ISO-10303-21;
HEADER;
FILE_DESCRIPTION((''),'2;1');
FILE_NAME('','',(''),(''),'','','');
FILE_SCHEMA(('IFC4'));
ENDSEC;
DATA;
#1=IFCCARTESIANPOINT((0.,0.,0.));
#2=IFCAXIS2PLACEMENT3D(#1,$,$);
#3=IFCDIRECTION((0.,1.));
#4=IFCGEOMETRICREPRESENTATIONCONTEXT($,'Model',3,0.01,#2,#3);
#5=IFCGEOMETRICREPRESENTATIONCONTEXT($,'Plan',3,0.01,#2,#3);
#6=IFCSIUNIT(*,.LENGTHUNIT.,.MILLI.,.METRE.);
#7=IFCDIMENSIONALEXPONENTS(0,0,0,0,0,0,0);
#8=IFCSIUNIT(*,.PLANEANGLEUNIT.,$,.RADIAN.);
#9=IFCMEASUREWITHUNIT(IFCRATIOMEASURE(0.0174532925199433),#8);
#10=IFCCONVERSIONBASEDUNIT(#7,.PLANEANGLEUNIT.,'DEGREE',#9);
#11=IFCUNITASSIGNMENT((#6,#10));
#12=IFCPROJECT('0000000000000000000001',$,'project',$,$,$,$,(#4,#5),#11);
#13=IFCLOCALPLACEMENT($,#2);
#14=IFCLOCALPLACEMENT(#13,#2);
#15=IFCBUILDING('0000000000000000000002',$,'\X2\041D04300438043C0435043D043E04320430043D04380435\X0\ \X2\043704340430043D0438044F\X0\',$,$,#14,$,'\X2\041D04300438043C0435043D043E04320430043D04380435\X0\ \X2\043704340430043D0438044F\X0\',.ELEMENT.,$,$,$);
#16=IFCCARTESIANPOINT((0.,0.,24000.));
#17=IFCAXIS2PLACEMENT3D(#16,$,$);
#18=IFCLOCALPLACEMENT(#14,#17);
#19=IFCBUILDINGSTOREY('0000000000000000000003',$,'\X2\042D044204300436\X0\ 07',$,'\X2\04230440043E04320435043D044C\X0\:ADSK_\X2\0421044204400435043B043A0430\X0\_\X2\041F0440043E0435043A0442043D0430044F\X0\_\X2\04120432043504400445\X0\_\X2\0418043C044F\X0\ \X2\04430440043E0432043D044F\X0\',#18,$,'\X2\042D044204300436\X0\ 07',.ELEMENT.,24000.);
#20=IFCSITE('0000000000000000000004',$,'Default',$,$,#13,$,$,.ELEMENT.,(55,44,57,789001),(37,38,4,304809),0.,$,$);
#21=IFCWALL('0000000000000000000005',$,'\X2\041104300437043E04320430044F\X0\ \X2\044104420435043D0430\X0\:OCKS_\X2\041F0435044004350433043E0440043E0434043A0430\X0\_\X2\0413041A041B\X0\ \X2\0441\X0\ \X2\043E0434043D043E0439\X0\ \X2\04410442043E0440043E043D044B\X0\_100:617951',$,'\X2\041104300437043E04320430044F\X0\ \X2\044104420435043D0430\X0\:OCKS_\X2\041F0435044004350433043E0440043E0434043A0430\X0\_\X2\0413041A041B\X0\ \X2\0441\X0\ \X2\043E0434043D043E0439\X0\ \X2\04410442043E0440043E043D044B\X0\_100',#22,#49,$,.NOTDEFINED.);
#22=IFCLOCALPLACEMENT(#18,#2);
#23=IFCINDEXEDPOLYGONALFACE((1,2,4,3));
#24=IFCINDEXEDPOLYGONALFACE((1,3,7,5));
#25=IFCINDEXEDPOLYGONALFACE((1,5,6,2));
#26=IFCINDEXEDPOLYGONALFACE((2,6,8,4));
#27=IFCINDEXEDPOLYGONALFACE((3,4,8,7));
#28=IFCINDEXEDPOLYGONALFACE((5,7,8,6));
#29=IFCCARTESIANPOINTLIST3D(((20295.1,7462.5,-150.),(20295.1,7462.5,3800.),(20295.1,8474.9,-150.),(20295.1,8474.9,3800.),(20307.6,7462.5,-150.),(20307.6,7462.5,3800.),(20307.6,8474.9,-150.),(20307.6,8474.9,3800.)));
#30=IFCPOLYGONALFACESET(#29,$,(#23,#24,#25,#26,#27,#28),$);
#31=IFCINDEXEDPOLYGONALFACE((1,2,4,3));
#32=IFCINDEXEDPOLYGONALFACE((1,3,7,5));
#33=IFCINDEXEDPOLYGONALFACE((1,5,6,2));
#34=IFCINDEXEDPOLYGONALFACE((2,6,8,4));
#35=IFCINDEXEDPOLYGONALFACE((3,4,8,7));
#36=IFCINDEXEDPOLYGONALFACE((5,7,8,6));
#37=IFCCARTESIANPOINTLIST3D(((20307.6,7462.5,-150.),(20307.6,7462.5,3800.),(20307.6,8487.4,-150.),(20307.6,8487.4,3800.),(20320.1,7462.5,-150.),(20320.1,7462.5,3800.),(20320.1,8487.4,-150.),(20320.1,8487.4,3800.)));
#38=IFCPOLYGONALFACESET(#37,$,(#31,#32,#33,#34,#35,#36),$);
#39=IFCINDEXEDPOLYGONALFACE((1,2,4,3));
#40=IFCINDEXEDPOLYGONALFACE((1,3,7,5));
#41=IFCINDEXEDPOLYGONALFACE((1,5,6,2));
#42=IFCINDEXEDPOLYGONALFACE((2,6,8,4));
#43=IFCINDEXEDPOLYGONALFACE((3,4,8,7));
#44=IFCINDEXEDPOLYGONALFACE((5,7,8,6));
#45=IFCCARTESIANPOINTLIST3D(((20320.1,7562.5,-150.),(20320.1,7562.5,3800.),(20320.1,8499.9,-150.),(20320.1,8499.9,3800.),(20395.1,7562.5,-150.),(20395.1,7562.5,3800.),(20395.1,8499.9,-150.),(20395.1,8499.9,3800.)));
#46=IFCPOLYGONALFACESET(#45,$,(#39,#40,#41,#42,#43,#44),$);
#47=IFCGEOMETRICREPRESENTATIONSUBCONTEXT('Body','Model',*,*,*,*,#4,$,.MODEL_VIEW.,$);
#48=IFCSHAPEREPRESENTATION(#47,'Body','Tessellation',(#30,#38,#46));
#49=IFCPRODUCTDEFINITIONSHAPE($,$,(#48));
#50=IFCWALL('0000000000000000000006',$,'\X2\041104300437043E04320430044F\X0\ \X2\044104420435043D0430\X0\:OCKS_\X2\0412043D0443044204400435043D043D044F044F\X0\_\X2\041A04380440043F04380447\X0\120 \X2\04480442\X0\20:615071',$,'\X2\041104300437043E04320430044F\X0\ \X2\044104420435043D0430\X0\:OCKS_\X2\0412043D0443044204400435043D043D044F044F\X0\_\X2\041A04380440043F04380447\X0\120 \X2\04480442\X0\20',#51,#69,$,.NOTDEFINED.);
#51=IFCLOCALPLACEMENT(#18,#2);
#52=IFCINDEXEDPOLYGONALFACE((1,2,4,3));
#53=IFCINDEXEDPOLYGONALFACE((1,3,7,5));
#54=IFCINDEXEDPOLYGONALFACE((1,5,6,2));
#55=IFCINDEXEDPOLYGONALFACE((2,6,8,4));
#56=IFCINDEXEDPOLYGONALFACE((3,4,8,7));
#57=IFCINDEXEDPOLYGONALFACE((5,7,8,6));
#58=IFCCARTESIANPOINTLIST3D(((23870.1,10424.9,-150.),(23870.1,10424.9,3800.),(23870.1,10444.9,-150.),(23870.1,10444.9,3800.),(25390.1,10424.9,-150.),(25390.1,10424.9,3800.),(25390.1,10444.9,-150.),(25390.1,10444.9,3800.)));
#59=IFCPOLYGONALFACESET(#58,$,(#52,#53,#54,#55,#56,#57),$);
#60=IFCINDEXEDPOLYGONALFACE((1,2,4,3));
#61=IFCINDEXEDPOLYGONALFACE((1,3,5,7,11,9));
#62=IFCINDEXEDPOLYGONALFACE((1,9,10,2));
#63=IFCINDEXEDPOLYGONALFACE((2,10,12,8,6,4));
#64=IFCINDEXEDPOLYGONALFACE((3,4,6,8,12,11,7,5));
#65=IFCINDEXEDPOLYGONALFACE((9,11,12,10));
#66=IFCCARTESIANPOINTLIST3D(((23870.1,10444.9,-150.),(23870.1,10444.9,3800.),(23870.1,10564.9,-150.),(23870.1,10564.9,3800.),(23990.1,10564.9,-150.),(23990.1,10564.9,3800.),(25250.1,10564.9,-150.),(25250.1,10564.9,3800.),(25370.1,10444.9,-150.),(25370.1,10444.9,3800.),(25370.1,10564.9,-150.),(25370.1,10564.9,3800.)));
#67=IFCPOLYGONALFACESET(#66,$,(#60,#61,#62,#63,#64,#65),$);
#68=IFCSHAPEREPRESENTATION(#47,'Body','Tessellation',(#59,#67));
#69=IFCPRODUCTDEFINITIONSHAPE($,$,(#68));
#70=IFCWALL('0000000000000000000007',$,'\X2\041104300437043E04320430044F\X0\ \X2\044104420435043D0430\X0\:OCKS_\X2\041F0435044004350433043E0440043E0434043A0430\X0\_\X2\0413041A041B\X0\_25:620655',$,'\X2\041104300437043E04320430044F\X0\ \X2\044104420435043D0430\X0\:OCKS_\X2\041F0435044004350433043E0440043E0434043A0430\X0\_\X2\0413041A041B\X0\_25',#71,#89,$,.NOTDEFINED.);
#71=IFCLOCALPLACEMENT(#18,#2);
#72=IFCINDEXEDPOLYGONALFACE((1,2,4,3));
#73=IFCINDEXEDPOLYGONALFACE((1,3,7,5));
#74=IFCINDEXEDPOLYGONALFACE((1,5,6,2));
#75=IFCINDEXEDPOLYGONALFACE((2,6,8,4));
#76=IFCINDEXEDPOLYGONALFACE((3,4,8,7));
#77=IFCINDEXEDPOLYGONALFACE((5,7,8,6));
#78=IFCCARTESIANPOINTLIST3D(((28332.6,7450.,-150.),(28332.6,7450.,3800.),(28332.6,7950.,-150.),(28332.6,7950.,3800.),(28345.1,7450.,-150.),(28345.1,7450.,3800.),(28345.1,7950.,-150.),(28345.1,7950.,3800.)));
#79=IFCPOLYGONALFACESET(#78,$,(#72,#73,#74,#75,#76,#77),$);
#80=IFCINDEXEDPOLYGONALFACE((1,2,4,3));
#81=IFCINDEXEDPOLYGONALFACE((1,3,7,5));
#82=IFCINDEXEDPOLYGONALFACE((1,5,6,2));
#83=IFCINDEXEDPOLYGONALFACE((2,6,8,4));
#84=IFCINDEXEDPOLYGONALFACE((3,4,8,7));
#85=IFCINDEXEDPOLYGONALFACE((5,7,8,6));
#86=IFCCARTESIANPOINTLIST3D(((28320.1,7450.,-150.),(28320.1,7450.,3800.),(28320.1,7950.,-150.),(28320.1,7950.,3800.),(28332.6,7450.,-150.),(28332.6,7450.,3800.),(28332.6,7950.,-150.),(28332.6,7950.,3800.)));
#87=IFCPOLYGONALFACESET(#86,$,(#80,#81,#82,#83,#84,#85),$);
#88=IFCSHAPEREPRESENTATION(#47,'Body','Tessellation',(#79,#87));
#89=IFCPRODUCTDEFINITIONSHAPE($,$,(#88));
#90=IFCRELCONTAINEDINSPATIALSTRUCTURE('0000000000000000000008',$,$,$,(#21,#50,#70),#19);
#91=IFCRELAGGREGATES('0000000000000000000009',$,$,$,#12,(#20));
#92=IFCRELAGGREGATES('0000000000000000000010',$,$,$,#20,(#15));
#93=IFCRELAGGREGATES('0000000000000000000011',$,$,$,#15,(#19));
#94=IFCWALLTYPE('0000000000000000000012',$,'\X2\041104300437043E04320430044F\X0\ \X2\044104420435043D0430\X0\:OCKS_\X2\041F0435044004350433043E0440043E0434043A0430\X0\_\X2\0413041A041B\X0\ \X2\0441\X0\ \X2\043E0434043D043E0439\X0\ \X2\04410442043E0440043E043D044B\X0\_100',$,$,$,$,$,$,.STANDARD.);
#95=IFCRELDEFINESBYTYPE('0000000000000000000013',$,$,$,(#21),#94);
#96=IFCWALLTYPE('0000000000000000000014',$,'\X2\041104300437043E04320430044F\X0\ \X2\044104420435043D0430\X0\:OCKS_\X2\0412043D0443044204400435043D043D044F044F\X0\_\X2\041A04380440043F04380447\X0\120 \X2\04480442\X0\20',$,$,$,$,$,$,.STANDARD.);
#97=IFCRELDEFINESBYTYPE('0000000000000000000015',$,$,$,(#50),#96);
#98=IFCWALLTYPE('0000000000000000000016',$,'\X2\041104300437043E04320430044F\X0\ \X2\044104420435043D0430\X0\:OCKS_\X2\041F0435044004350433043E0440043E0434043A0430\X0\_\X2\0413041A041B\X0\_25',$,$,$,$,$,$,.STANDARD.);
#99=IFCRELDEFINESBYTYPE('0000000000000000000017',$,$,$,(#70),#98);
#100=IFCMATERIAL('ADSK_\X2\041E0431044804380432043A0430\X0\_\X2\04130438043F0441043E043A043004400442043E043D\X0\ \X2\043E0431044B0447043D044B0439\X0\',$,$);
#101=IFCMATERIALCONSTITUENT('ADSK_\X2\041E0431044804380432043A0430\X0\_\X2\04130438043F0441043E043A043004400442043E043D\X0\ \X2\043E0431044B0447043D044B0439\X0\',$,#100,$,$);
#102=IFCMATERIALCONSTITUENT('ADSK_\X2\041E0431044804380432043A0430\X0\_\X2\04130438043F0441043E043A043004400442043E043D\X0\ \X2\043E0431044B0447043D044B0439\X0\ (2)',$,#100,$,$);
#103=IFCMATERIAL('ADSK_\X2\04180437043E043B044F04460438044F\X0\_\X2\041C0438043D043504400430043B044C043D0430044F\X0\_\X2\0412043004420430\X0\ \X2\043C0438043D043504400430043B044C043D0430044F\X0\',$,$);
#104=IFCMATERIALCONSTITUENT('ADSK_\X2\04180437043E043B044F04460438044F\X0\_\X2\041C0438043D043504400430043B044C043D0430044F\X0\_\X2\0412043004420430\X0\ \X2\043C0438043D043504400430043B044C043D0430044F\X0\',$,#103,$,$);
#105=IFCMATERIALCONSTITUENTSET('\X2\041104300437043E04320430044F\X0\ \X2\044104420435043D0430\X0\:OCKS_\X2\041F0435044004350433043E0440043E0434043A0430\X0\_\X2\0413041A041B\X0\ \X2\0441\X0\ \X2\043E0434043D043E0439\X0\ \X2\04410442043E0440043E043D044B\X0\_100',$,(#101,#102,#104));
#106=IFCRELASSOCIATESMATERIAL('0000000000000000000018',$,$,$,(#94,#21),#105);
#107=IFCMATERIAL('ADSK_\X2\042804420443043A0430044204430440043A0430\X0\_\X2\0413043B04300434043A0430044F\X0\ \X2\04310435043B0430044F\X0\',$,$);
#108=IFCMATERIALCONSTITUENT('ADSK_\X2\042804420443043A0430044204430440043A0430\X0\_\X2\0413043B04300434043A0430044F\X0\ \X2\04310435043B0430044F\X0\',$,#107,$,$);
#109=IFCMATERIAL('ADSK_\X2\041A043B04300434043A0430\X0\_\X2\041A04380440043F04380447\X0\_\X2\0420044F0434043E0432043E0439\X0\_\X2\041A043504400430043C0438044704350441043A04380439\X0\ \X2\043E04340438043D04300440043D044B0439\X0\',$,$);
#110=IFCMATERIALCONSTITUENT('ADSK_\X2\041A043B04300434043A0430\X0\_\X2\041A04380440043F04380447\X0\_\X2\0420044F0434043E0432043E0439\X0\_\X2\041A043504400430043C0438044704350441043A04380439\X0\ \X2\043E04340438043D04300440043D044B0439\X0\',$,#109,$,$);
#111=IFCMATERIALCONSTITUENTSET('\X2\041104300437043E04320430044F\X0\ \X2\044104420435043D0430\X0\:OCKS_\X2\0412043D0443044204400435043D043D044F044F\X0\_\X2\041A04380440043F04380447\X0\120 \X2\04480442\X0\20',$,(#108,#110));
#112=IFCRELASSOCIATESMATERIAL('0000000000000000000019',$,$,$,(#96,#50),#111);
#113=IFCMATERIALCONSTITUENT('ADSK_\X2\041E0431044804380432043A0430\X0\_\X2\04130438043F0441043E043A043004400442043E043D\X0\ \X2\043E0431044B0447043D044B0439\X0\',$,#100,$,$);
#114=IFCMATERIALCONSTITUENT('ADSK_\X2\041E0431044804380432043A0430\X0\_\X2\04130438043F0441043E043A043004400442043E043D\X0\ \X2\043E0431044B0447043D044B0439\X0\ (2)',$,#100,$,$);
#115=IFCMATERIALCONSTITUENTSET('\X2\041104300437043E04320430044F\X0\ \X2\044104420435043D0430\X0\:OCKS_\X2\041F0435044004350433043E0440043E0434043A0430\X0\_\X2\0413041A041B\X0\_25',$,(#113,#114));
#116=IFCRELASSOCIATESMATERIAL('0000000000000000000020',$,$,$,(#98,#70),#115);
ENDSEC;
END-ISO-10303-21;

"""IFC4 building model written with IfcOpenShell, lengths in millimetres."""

from ifc_helpers import new_model, entity, si_unit, converted_unit, direction, frame, origin, place, context, subcontext, project, spatial, indexed_curve, outline, extrude, material, constituent, constituent_set, type_object, element, save


model = new_model("IFC4")

# Units and contexts
model_context = context("Model", 3, precision=0.01, world=origin(), true_north=direction((0.0, 1.0)))
plan_context = context("Plan", 3, precision=0.01, world=origin(), true_north=direction((0.0, 1.0)))
body_context = subcontext(model_context, "Body", "Model", "MODEL_VIEW")
ifc_project = project(units=[si_unit("LENGTHUNIT", "METRE", prefix="MILLI"), converted_unit("PLANEANGLEUNIT", "DEGREE", entity("IfcRatioMeasure", 0.0174532925199433), si_unit("PLANEANGLEUNIT", "RADIAN"), dimensions=[0, 0, 0, 0, 0, 0, 0])], contexts=[model_context, plan_context])

# Site, building, storey
site_placement = place(None, frame((0.0, 0.0, 0.0)))
site = spatial("IfcSite", under=ifc_project, at=site_placement, Name="Default", CompositionType="ELEMENT", RefLatitude=(55, 44, 57, 789001), RefLongitude=(37, 38, 4, 304809), RefElevation=0.0)
building_placement = place(site_placement, origin())
building = spatial("IfcBuilding", under=site, at=building_placement, Name="Наименование здания", LongName="Наименование здания", CompositionType="ELEMENT")
storey_placement = place(building_placement, frame((0.0, 0.0, 24000.0)))
storey = spatial("IfcBuildingStorey", under=building, at=storey_placement, Name="Этаж 07", ObjectType="Уровень:ADSK_Стрелка_Проектная_Вверх_Имя уровня", LongName="Этаж 07", CompositionType="ELEMENT", Elevation=24000.0)

# Shared definitions
ifc_material_1 = material(Name="ADSK_Обшивка_Гипсокартон обычный")
ifc_material_2 = material(Name="ADSK_Изоляция_Минеральная_Вата минеральная")

# Walls
ifc_constituent_1 = constituent(ifc_material_1, Name="ADSK_Обшивка_Гипсокартон обычный")
ifc_constituent_2 = constituent(ifc_material_1, Name="ADSK_Обшивка_Гипсокартон обычный (2)")
ifc_constituent_3 = constituent(ifc_material_2, Name="ADSK_Изоляция_Минеральная_Вата минеральная")
ifc_constituent_set_1 = constituent_set(constituents=[ifc_constituent_1, ifc_constituent_2, ifc_constituent_3], Name="Базовая стена:OCKS_Перегородка_ГКЛ с одной стороны_100")
wall_type_1 = type_object("IfcWallType", Name="Базовая стена:OCKS_Перегородка_ГКЛ с одной стороны_100", PredefinedType="STANDARD", material=ifc_constituent_set_1)
wall_1_placement = place(storey_placement, frame((20345.1, 7562.5, -150.0), z_axis=(0.0, 0.0, 1.0), x_axis=(0.0, 1.0, 0.0)))
element("IfcWall", 1, at=wall_1_placement, inside=storey, type_object=wall_type_1, material=ifc_constituent_set_1, Name="Базовая стена:OCKS_Перегородка_ГКЛ с одной стороны_100:617951", ObjectType="Базовая стена:OCKS_Перегородка_ГКЛ с одной стороны_100", PredefinedType="NOTDEFINED", context=body_context, shape_type="SweptSolid", body=[
    extrude(outline(indexed_curve([(-6.3, -506.2), (6.2, -506.2), (6.2, 506.2), (-6.3, 506.2), (-6.3, -506.2)], self_intersect=False)), frame((406.2, 43.7, 0.0), z_axis=(0.0, 0.0, 1.0), x_axis=(0.0, -1.0, 0.0)), (0.0, 0.0, 1.0), 3950.0),
    extrude(outline(indexed_curve([(-512.5, -6.3), (512.5, -6.3), (512.5, 6.2), (-512.5, 6.2), (-512.5, -6.3)], self_intersect=False)), frame((412.5, 31.3, 0.0)), (0.0, 0.0, 1.0), 3950.0),
    extrude(outline(indexed_curve([(-37.5, -468.7), (37.5, -468.7), (37.5, 468.7), (-37.5, 468.7), (-37.5, -468.7)], self_intersect=False)), frame((468.7, -12.5, 0.0), z_axis=(0.0, 0.0, 1.0), x_axis=(0.0, 1.0, 0.0)), (0.0, 0.0, 1.0), 3950.0),
])
ifc_material_3 = material(Name="ADSK_Штукатурка_Гладкая белая")
ifc_constituent_4 = constituent(ifc_material_3, Name="ADSK_Штукатурка_Гладкая белая")
ifc_material_4 = material(Name="ADSK_Кладка_Кирпич_Рядовой_Керамический одинарный")
ifc_constituent_5 = constituent(ifc_material_4, Name="ADSK_Кладка_Кирпич_Рядовой_Керамический одинарный")
ifc_constituent_set_2 = constituent_set(constituents=[ifc_constituent_4, ifc_constituent_5], Name="Базовая стена:OCKS_Внутренняя_Кирпич120 шт20")
wall_type_2 = type_object("IfcWallType", Name="Базовая стена:OCKS_Внутренняя_Кирпич120 шт20", PredefinedType="STANDARD", material=ifc_constituent_set_2)
wall_2_placement = place(storey_placement, frame((23870.1, 10494.9, -150.0)))
element("IfcWall", 2, at=wall_2_placement, inside=storey, type_object=wall_type_2, material=ifc_constituent_set_2, Name="Базовая стена:OCKS_Внутренняя_Кирпич120 шт20:615071", ObjectType="Базовая стена:OCKS_Внутренняя_Кирпич120 шт20", PredefinedType="NOTDEFINED", context=body_context, shape_type="SweptSolid", body=[
    extrude(outline(indexed_curve([(-10.0, -760.0), (10.0, -760.0), (10.0, 760.0), (-10.0, 760.0), (-10.0, -760.0)], self_intersect=False)), frame((760.0, -60.0, 0.0), z_axis=(0.0, 0.0, 1.0), x_axis=(0.0, 1.0, 0.0)), (0.0, 0.0, 1.0), 3950.0),
    extrude(outline(indexed_curve([(-630.0, -40.0), (630.0, -40.0), (750.0, -40.0), (750.0, 80.0), (-750.0, 80.0), (-750.0, -40.0), (-630.0, -40.0)], self_intersect=False)), frame((750.0, 30.0, 0.0), z_axis=(0.0, 0.0, 1.0), x_axis=(-1.0, 0.0, 0.0)), (0.0, 0.0, 1.0), 3950.0),
])
ifc_constituent_6 = constituent(ifc_material_1, Name="ADSK_Обшивка_Гипсокартон обычный")
ifc_constituent_7 = constituent(ifc_material_1, Name="ADSK_Обшивка_Гипсокартон обычный (2)")
ifc_constituent_set_3 = constituent_set(constituents=[ifc_constituent_6, ifc_constituent_7], Name="Базовая стена:OCKS_Перегородка_ГКЛ_25")
wall_type_3 = type_object("IfcWallType", Name="Базовая стена:OCKS_Перегородка_ГКЛ_25", PredefinedType="STANDARD", material=ifc_constituent_set_3)
wall_3_placement = place(storey_placement, frame((28332.6, 7450.0, -150.0), z_axis=(0.0, 0.0, 1.0), x_axis=(0.0, 1.0, 0.0)))
element("IfcWall", 3, at=wall_3_placement, inside=storey, type_object=wall_type_3, material=ifc_constituent_set_3, Name="Базовая стена:OCKS_Перегородка_ГКЛ_25:620655", ObjectType="Базовая стена:OCKS_Перегородка_ГКЛ_25", PredefinedType="NOTDEFINED", context=body_context, shape_type="SweptSolid", body=[
    extrude(outline(indexed_curve([(-6.2, -250.0), (6.2, -250.0), (6.2, 250.0), (-6.2, 250.0), (-6.2, -250.0)], self_intersect=False)), frame((250.0, -6.2, 0.0), z_axis=(0.0, 0.0, 1.0), x_axis=(0.0, 1.0, 0.0)), (0.0, 0.0, 1.0), 3950.0),
    extrude(outline(indexed_curve([(-6.3, -250.0), (6.2, -250.0), (6.2, 250.0), (-6.3, 250.0), (-6.3, -250.0)], self_intersect=False)), frame((250.0, 6.2, 0.0), z_axis=(0.0, 0.0, 1.0), x_axis=(0.0, -1.0, 0.0)), (0.0, 0.0, 1.0), 3950.0),
])

save(model, "model.ifc")
